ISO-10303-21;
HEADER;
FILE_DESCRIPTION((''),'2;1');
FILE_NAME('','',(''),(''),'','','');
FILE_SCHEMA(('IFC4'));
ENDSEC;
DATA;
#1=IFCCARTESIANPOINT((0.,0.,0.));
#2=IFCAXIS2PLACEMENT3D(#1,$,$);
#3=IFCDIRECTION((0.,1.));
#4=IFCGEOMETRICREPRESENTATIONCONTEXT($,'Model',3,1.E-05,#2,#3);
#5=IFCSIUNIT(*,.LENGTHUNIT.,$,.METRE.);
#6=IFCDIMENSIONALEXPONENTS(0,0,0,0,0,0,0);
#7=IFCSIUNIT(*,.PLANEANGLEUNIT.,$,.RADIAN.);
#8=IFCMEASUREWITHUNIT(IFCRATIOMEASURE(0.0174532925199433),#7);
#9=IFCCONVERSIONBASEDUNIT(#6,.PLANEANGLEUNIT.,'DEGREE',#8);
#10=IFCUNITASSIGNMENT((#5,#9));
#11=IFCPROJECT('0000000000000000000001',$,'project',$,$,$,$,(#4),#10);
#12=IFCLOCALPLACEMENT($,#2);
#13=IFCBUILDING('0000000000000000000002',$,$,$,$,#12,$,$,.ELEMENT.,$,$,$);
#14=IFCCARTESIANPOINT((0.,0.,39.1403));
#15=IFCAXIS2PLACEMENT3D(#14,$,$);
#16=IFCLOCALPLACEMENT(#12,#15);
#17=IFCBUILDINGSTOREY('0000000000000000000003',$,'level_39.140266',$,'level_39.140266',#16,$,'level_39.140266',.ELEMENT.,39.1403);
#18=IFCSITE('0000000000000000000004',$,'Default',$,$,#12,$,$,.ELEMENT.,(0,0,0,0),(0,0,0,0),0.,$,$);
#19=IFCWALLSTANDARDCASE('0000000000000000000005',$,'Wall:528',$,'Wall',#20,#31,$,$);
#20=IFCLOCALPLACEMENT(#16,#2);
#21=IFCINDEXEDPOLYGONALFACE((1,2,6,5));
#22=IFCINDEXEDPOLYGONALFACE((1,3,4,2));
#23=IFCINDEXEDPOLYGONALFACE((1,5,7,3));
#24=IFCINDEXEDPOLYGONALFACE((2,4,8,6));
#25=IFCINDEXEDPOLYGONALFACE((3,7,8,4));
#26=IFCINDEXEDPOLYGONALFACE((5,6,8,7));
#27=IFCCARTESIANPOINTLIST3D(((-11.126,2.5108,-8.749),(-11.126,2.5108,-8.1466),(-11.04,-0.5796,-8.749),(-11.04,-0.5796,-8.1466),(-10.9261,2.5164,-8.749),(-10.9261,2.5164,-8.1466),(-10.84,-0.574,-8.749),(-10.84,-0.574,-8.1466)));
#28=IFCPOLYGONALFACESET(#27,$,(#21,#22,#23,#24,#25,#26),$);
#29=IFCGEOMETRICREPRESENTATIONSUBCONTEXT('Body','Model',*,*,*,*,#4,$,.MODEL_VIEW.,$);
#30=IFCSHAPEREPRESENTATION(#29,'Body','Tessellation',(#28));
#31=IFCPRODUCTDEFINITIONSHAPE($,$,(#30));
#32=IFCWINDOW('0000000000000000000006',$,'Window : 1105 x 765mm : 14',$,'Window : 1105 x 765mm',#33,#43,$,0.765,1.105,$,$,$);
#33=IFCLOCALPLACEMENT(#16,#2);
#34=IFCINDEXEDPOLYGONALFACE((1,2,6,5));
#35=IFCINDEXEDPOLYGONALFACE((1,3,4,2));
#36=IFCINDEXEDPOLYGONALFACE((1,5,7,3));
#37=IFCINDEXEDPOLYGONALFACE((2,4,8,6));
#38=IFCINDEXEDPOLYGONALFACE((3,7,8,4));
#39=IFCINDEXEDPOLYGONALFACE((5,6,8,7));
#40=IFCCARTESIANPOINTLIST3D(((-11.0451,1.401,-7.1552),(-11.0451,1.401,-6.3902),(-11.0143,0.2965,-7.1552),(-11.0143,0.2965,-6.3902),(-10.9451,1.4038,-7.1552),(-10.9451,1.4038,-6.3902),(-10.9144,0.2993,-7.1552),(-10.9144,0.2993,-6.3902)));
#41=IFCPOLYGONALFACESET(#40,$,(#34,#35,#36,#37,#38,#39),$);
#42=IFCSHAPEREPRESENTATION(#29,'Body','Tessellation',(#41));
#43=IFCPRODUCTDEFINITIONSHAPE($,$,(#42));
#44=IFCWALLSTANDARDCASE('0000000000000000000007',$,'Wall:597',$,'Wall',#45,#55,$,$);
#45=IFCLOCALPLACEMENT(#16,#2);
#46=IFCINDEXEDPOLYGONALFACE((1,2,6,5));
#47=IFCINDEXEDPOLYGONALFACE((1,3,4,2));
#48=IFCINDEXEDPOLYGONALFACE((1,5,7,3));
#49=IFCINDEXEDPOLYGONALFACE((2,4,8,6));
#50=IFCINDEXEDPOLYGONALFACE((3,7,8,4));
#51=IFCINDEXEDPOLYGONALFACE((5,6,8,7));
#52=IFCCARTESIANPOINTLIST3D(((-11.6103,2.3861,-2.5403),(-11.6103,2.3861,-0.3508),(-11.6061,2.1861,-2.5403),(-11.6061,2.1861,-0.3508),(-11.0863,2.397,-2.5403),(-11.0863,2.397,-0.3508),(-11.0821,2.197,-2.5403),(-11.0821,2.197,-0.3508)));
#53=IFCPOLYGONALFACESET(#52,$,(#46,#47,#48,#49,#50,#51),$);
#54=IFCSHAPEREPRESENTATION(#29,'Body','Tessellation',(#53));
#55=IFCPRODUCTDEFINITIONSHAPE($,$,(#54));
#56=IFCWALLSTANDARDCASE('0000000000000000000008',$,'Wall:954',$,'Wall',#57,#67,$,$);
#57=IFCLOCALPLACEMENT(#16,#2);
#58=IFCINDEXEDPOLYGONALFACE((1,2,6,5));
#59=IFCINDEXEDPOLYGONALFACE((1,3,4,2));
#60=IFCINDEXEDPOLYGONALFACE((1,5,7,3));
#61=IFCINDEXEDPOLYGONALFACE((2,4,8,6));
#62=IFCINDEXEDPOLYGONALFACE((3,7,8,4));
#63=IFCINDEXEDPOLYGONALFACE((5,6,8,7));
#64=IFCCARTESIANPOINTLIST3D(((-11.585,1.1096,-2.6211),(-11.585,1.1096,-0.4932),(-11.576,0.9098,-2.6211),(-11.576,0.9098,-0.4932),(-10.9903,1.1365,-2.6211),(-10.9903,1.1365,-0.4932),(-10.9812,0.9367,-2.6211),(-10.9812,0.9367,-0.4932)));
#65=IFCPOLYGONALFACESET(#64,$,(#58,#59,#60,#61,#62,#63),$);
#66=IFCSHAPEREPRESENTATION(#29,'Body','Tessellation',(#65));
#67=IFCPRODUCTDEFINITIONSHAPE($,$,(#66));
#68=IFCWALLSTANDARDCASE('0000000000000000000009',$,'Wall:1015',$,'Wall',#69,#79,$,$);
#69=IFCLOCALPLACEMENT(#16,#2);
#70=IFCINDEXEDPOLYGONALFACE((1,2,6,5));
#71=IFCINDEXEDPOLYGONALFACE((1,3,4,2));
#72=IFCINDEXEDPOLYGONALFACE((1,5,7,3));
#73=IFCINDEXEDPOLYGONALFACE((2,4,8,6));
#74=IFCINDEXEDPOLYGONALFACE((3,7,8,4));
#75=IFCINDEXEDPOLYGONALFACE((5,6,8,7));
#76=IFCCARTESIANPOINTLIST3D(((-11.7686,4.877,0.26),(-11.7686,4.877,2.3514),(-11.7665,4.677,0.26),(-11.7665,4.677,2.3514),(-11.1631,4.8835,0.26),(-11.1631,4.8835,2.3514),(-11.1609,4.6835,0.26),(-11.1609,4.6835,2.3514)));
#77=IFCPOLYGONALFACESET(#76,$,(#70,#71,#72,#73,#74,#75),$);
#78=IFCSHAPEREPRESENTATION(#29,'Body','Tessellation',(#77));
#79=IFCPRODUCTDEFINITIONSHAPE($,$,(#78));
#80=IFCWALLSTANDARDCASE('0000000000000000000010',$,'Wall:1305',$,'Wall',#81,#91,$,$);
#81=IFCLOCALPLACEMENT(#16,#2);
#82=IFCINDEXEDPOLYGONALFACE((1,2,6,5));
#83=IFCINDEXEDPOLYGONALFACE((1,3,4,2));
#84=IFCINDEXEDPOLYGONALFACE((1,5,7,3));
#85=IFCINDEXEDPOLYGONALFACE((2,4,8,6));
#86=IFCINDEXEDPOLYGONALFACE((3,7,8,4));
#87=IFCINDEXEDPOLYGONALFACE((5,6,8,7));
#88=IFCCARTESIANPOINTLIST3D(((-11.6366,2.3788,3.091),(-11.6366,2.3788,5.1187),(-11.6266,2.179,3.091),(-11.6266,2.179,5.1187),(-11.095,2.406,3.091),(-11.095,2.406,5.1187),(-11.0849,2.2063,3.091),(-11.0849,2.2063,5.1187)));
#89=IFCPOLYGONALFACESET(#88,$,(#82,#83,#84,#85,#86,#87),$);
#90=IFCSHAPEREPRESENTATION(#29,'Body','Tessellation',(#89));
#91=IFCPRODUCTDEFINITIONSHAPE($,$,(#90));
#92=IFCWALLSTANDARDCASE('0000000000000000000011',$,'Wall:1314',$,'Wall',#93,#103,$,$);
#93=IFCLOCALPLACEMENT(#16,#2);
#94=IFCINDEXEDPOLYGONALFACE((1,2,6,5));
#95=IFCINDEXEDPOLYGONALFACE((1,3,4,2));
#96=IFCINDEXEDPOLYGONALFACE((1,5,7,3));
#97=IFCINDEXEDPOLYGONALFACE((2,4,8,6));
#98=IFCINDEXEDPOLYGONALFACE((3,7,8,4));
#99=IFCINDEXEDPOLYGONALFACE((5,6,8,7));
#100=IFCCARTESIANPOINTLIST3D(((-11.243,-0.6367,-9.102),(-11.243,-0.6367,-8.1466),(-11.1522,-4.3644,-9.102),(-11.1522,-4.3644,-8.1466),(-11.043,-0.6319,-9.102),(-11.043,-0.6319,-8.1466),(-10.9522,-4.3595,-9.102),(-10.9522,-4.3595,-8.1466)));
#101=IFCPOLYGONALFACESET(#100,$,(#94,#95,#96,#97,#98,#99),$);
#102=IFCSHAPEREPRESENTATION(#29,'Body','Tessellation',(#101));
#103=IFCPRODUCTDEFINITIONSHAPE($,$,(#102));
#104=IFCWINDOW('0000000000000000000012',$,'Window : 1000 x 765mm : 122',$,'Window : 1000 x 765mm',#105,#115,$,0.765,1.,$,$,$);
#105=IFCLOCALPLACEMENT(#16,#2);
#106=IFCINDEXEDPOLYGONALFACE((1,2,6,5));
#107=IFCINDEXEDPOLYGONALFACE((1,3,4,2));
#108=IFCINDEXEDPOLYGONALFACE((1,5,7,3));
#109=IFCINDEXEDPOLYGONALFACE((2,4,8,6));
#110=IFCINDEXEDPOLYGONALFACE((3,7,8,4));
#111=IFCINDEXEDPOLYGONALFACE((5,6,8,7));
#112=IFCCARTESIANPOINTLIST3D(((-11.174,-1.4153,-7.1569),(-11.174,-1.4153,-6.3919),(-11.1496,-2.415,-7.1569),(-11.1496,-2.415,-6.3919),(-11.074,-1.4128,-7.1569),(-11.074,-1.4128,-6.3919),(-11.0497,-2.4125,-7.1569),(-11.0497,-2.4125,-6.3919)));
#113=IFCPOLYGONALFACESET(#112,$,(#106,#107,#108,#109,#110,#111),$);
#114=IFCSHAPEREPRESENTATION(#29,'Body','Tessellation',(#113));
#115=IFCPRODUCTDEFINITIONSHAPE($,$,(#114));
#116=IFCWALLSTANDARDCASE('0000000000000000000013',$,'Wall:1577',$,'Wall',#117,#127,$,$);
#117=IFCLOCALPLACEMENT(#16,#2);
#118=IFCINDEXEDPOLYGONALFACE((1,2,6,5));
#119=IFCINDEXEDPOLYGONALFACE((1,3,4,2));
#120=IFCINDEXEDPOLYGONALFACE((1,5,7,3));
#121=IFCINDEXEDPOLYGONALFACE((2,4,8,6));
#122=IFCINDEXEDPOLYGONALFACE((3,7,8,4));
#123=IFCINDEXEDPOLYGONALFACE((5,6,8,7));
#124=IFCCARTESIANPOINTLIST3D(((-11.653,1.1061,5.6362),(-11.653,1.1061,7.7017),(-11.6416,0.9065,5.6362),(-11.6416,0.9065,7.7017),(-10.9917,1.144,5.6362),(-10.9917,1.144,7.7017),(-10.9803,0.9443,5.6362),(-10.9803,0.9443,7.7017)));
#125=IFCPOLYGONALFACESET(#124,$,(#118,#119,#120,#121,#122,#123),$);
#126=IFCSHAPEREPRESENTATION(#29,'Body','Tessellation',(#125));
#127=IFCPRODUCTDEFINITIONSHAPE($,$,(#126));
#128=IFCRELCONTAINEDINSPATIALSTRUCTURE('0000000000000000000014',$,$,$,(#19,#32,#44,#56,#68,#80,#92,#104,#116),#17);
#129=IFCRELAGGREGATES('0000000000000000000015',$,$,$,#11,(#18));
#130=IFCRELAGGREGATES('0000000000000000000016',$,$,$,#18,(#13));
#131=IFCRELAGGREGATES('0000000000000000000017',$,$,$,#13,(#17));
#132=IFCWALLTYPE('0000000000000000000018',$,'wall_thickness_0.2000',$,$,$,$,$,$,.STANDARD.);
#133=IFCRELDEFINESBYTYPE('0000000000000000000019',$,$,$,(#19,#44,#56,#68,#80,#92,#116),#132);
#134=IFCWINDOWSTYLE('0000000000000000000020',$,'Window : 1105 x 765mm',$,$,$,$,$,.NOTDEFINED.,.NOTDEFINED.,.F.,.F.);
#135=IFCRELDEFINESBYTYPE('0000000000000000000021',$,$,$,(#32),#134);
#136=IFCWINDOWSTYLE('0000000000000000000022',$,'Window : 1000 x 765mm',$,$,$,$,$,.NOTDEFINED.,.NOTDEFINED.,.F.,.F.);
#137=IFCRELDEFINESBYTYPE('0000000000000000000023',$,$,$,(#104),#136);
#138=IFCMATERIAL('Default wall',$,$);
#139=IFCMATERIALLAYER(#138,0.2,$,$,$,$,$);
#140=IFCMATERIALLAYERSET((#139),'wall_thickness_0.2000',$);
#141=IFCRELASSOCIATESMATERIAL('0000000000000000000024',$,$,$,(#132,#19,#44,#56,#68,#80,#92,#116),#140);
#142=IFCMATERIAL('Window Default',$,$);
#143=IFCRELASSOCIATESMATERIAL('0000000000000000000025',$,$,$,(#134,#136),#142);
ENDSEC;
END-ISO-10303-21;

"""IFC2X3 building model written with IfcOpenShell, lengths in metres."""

from ifc_helpers import new_model, entity, si_unit, converted_unit, direction, frame, frame_2d, origin, origin_2d_with_axis, place, context, subcontext, project, spatial, polyline, rectangle, outline, extrude, source, transform, mapped, material, layer, layer_set, layer_usage, type_object, type_shapes, element, fill, save


model = new_model("IFC2X3")

# Units and contexts
model_context = context("Model", 3, precision=1e-05, world=origin(), true_north=direction((0.0, 1.0)))
body_context = subcontext(model_context, "Body", "Model", "MODEL_VIEW")
ifc_project = project(units=[si_unit("LENGTHUNIT", "METRE"), converted_unit("PLANEANGLEUNIT", "DEGREE", entity("IfcRatioMeasure", 0.0174532925199433), si_unit("PLANEANGLEUNIT", "RADIAN"), dimensions=[0, 0, 0, 0, 0, 0, 0])], contexts=[model_context])

# Site, building, storey
placement_1 = place(None, origin())
site = spatial("IfcSite", under=ifc_project, at=placement_1, Name="Default", CompositionType="ELEMENT", RefLatitude=(0, 0, 0, 0), RefLongitude=(0, 0, 0, 0), RefElevation=0.0)
building = spatial("IfcBuilding", under=site, at=placement_1, CompositionType="ELEMENT")
storey_placement = place(placement_1, frame((0.0, 0.0, 39.1403)))
storey = spatial("IfcBuildingStorey", under=building, at=storey_placement, Name="level_39.140266", ObjectType="level_39.140266", LongName="level_39.140266", CompositionType="ELEMENT", Elevation=39.1403)

# Shared definitions
ifc_material_1 = material(Name="Default wall")
ifc_layer = layer(ifc_material_1, 0.2)
ifc_layer_set = layer_set([ifc_layer], Name="wall_thickness_0.2000")
ifc_layer_usage = layer_usage(ifc_layer_set, "AXIS2", "POSITIVE", -0.1)
wall_type = type_object("IfcWallType", Name="wall_thickness_0.2000", PredefinedType="STANDARD", material=ifc_layer_set)
ifc_material_2 = material(Name="Window Default")

# Wall, opening, window
placement_2 = place(placement_1, frame((0.0, 0.0, 30.3913)))
wall_1_placement = place(placement_2, frame((-10.94, -0.5768, 0.0), z_axis=(0.0, 0.0, 1.0), x_axis=(-0.027824, 0.999613, 0.0)))
wall_1 = element("IfcWallStandardCase", 1, at=wall_1_placement, inside=storey, type_object=wall_type, material=ifc_layer_usage, Name="Wall:528", ObjectType="Wall", context=body_context, shape_type="SweptSolid", body=[
    extrude(outline(polyline([(3.0916, -0.1), (3.0916, 0.1), (0.0, 0.1), (0.0, -0.1), (3.0916, -0.1)])), origin(), (0.0, 0.0, 1.0), 0.6024),
])
opening_1_placement = place(wall_1_placement, frame((0.875, -0.1, 1.5938)))
opening_1 = element("IfcOpeningElement", 2, at=opening_1_placement, cuts=wall_1, ObjectType="Opening", context=body_context, shape_type="SweptSolid", body=[
    extrude(rectangle(XDim=1.105, YDim=0.765, at=frame_2d((0.3825, 0.5525), x_axis=(0.0, 1.0))), frame((0.0, 0.0, 0.0), z_axis=(0.0, 1.0, 0.0), x_axis=(0.0, 0.0, 1.0)), (0.0, 0.0, 1.0), 0.2),
])
window_style_1 = type_object("IfcWindowStyle", Name="Window : 1105 x 765mm", ConstructionType="NOTDEFINED", OperationType="NOTDEFINED", ParameterTakesPrecedence=False, Sizeable=False, material=ifc_material_2)
shared_shape_1 = source(origin(), body_context, "Body", "SweptSolid", [
    extrude(rectangle(XDim=0.1, YDim=1.105, at=origin_2d_with_axis()), frame((0.5525, 0.1, 0.0), z_axis=(0.0, 0.0, 1.0), x_axis=(0.0, 1.0, 0.0)), (0.0, 0.0, 1.0), 0.765),
])
type_shapes(window_style_1, [shared_shape_1])
window_1_placement = place(opening_1_placement, origin())
window_1 = element("IfcWindow", 3, at=window_1_placement, inside=storey, type_object=window_style_1, Name="Window : 1105 x 765mm : 14", ObjectType="Window : 1105 x 765mm", OverallHeight=0.765, OverallWidth=1.105, context=body_context, shape_type="MappedRepresentation", body=[
    mapped(shared_shape_1, transform((0.0, 0.0, 0.0), scale=1.0)),
])
fill(opening_1, window_1)

# Walls
placement_3 = place(placement_1, frame((0.0, 0.0, 36.6)))
wall_2_placement = place(placement_3, frame((-11.0842, 2.297, 0.0), z_axis=(0.0, 0.0, 1.0), x_axis=(-0.999783, -0.020849, 0.0)))
element("IfcWallStandardCase", 4, at=wall_2_placement, inside=storey, type_object=wall_type, material=ifc_layer_usage, Name="Wall:597", ObjectType="Wall", context=body_context, shape_type="SweptSolid", body=[
    extrude(outline(polyline([(0.5241, -0.1), (0.5241, 0.1), (0.0, 0.1), (0.0, -0.1), (0.5241, -0.1)])), origin(), (0.0, 0.0, 1.0), 2.1895),
])
placement_4 = place(placement_1, frame((0.0, 0.0, 36.5192)))
wall_3_placement = place(placement_4, frame((-10.9858, 1.0366, 0.0), z_axis=(0.0, 0.0, 1.0), x_axis=(-0.998975, -0.045256, 0.0)))
element("IfcWallStandardCase", 5, at=wall_3_placement, inside=storey, type_object=wall_type, material=ifc_layer_usage, Name="Wall:954", ObjectType="Wall", context=body_context, shape_type="SweptSolid", body=[
    extrude(outline(polyline([(0.5953, -0.1), (0.5953, 0.1), (0.0, 0.1), (0.0, -0.1), (0.5953, -0.1)])), origin(), (0.0, 0.0, 1.0), 2.1279),
])
placement_5 = place(placement_1, frame((0.0, 0.0, 39.4003)))
wall_4_placement = place(placement_5, frame((-11.162, 4.7835, 0.0), z_axis=(0.0, 0.0, 1.0), x_axis=(-0.999942, -0.010811, 0.0)))
element("IfcWallStandardCase", 6, at=wall_4_placement, inside=storey, type_object=wall_type, material=ifc_layer_usage, Name="Wall:1015", ObjectType="Wall", context=body_context, shape_type="SweptSolid", body=[
    extrude(outline(polyline([(0.6056, -0.1), (0.6056, 0.1), (0.0, 0.1), (0.0, -0.1), (0.6056, -0.1)])), origin(), (0.0, 0.0, 1.0), 2.0914),
])
placement_6 = place(placement_1, frame((0.0, 0.0, 42.2313)))
wall_5_placement = place(placement_6, frame((-11.0899, 2.3062, 0.0), z_axis=(0.0, 0.0, 1.0), x_axis=(-0.998736, -0.050265, 0.0)))
element("IfcWallStandardCase", 7, at=wall_5_placement, inside=storey, type_object=wall_type, material=ifc_layer_usage, Name="Wall:1305", ObjectType="Wall", context=body_context, shape_type="SweptSolid", body=[
    extrude(outline(polyline([(0.5423, -0.1), (0.5423, 0.1), (0.0, 0.1), (0.0, -0.1), (0.5423, -0.1)])), origin(), (0.0, 0.0, 1.0), 2.0278),
])

# Wall, opening, window
placement_7 = place(placement_1, frame((0.0, 0.0, 30.0383)))
wall_6_placement = place(placement_7, frame((-11.0522, -4.362, 0.0), z_axis=(0.0, 0.0, 1.0), x_axis=(-0.024357, 0.999703, 0.0)))
wall_6 = element("IfcWallStandardCase", 8, at=wall_6_placement, inside=storey, type_object=wall_type, material=ifc_layer_usage, Name="Wall:1314", ObjectType="Wall", context=body_context, shape_type="SweptSolid", body=[
    extrude(outline(polyline([(3.7288, -0.1), (3.7288, 0.1), (0.0, 0.1), (0.0, -0.1), (3.7288, -0.1)])), origin(), (0.0, 0.0, 1.0), 0.9554),
])
opening_2_placement = place(wall_6_placement, frame((1.9488, -0.1, 1.9451)))
opening_2 = element("IfcOpeningElement", 9, at=opening_2_placement, cuts=wall_6, ObjectType="Opening", context=body_context, shape_type="SweptSolid", body=[
    extrude(rectangle(XDim=1.0, YDim=0.765, at=frame_2d((0.3825, 0.5), x_axis=(0.0, 1.0))), frame((0.0, 0.0, 0.0), z_axis=(0.0, 1.0, 0.0), x_axis=(0.0, 0.0, 1.0)), (0.0, 0.0, 1.0), 0.2),
])
window_style_2 = type_object("IfcWindowStyle", Name="Window : 1000 x 765mm", ConstructionType="NOTDEFINED", OperationType="NOTDEFINED", ParameterTakesPrecedence=False, Sizeable=False, material=ifc_material_2)
shared_shape_2 = source(origin(), body_context, "Body", "SweptSolid", [
    extrude(rectangle(XDim=0.1, YDim=1.0, at=origin_2d_with_axis()), frame((0.5, 0.1, 0.0), z_axis=(0.0, 0.0, 1.0), x_axis=(0.0, 1.0, 0.0)), (0.0, 0.0, 1.0), 0.765),
])
type_shapes(window_style_2, [shared_shape_2])
window_2_placement = place(opening_2_placement, origin())
window_2 = element("IfcWindow", 10, at=window_2_placement, inside=storey, type_object=window_style_2, Name="Window : 1000 x 765mm : 122", ObjectType="Window : 1000 x 765mm", OverallHeight=0.765, OverallWidth=1.0, context=body_context, shape_type="MappedRepresentation", body=[
    mapped(shared_shape_2, transform((0.0, 0.0, 0.0), scale=1.0)),
])
fill(opening_2, window_2)

# Wall
placement_8 = place(placement_1, frame((0.0, 0.0, 44.7765)))
wall_7_placement = place(placement_8, frame((-10.986, 1.0441, 0.0), z_axis=(0.0, 0.0, 1.0), x_axis=(-0.99837, -0.05708, 0.0)))
element("IfcWallStandardCase", 11, at=wall_7_placement, inside=storey, type_object=wall_type, material=ifc_layer_usage, Name="Wall:1577", ObjectType="Wall", context=body_context, shape_type="SweptSolid", body=[
    extrude(outline(polyline([(0.6624, -0.1), (0.6624, 0.1), (0.0, 0.1), (0.0, -0.1), (0.6624, -0.1)])), origin(), (0.0, 0.0, 1.0), 2.0655),
])

save(model, "model.ifc")
